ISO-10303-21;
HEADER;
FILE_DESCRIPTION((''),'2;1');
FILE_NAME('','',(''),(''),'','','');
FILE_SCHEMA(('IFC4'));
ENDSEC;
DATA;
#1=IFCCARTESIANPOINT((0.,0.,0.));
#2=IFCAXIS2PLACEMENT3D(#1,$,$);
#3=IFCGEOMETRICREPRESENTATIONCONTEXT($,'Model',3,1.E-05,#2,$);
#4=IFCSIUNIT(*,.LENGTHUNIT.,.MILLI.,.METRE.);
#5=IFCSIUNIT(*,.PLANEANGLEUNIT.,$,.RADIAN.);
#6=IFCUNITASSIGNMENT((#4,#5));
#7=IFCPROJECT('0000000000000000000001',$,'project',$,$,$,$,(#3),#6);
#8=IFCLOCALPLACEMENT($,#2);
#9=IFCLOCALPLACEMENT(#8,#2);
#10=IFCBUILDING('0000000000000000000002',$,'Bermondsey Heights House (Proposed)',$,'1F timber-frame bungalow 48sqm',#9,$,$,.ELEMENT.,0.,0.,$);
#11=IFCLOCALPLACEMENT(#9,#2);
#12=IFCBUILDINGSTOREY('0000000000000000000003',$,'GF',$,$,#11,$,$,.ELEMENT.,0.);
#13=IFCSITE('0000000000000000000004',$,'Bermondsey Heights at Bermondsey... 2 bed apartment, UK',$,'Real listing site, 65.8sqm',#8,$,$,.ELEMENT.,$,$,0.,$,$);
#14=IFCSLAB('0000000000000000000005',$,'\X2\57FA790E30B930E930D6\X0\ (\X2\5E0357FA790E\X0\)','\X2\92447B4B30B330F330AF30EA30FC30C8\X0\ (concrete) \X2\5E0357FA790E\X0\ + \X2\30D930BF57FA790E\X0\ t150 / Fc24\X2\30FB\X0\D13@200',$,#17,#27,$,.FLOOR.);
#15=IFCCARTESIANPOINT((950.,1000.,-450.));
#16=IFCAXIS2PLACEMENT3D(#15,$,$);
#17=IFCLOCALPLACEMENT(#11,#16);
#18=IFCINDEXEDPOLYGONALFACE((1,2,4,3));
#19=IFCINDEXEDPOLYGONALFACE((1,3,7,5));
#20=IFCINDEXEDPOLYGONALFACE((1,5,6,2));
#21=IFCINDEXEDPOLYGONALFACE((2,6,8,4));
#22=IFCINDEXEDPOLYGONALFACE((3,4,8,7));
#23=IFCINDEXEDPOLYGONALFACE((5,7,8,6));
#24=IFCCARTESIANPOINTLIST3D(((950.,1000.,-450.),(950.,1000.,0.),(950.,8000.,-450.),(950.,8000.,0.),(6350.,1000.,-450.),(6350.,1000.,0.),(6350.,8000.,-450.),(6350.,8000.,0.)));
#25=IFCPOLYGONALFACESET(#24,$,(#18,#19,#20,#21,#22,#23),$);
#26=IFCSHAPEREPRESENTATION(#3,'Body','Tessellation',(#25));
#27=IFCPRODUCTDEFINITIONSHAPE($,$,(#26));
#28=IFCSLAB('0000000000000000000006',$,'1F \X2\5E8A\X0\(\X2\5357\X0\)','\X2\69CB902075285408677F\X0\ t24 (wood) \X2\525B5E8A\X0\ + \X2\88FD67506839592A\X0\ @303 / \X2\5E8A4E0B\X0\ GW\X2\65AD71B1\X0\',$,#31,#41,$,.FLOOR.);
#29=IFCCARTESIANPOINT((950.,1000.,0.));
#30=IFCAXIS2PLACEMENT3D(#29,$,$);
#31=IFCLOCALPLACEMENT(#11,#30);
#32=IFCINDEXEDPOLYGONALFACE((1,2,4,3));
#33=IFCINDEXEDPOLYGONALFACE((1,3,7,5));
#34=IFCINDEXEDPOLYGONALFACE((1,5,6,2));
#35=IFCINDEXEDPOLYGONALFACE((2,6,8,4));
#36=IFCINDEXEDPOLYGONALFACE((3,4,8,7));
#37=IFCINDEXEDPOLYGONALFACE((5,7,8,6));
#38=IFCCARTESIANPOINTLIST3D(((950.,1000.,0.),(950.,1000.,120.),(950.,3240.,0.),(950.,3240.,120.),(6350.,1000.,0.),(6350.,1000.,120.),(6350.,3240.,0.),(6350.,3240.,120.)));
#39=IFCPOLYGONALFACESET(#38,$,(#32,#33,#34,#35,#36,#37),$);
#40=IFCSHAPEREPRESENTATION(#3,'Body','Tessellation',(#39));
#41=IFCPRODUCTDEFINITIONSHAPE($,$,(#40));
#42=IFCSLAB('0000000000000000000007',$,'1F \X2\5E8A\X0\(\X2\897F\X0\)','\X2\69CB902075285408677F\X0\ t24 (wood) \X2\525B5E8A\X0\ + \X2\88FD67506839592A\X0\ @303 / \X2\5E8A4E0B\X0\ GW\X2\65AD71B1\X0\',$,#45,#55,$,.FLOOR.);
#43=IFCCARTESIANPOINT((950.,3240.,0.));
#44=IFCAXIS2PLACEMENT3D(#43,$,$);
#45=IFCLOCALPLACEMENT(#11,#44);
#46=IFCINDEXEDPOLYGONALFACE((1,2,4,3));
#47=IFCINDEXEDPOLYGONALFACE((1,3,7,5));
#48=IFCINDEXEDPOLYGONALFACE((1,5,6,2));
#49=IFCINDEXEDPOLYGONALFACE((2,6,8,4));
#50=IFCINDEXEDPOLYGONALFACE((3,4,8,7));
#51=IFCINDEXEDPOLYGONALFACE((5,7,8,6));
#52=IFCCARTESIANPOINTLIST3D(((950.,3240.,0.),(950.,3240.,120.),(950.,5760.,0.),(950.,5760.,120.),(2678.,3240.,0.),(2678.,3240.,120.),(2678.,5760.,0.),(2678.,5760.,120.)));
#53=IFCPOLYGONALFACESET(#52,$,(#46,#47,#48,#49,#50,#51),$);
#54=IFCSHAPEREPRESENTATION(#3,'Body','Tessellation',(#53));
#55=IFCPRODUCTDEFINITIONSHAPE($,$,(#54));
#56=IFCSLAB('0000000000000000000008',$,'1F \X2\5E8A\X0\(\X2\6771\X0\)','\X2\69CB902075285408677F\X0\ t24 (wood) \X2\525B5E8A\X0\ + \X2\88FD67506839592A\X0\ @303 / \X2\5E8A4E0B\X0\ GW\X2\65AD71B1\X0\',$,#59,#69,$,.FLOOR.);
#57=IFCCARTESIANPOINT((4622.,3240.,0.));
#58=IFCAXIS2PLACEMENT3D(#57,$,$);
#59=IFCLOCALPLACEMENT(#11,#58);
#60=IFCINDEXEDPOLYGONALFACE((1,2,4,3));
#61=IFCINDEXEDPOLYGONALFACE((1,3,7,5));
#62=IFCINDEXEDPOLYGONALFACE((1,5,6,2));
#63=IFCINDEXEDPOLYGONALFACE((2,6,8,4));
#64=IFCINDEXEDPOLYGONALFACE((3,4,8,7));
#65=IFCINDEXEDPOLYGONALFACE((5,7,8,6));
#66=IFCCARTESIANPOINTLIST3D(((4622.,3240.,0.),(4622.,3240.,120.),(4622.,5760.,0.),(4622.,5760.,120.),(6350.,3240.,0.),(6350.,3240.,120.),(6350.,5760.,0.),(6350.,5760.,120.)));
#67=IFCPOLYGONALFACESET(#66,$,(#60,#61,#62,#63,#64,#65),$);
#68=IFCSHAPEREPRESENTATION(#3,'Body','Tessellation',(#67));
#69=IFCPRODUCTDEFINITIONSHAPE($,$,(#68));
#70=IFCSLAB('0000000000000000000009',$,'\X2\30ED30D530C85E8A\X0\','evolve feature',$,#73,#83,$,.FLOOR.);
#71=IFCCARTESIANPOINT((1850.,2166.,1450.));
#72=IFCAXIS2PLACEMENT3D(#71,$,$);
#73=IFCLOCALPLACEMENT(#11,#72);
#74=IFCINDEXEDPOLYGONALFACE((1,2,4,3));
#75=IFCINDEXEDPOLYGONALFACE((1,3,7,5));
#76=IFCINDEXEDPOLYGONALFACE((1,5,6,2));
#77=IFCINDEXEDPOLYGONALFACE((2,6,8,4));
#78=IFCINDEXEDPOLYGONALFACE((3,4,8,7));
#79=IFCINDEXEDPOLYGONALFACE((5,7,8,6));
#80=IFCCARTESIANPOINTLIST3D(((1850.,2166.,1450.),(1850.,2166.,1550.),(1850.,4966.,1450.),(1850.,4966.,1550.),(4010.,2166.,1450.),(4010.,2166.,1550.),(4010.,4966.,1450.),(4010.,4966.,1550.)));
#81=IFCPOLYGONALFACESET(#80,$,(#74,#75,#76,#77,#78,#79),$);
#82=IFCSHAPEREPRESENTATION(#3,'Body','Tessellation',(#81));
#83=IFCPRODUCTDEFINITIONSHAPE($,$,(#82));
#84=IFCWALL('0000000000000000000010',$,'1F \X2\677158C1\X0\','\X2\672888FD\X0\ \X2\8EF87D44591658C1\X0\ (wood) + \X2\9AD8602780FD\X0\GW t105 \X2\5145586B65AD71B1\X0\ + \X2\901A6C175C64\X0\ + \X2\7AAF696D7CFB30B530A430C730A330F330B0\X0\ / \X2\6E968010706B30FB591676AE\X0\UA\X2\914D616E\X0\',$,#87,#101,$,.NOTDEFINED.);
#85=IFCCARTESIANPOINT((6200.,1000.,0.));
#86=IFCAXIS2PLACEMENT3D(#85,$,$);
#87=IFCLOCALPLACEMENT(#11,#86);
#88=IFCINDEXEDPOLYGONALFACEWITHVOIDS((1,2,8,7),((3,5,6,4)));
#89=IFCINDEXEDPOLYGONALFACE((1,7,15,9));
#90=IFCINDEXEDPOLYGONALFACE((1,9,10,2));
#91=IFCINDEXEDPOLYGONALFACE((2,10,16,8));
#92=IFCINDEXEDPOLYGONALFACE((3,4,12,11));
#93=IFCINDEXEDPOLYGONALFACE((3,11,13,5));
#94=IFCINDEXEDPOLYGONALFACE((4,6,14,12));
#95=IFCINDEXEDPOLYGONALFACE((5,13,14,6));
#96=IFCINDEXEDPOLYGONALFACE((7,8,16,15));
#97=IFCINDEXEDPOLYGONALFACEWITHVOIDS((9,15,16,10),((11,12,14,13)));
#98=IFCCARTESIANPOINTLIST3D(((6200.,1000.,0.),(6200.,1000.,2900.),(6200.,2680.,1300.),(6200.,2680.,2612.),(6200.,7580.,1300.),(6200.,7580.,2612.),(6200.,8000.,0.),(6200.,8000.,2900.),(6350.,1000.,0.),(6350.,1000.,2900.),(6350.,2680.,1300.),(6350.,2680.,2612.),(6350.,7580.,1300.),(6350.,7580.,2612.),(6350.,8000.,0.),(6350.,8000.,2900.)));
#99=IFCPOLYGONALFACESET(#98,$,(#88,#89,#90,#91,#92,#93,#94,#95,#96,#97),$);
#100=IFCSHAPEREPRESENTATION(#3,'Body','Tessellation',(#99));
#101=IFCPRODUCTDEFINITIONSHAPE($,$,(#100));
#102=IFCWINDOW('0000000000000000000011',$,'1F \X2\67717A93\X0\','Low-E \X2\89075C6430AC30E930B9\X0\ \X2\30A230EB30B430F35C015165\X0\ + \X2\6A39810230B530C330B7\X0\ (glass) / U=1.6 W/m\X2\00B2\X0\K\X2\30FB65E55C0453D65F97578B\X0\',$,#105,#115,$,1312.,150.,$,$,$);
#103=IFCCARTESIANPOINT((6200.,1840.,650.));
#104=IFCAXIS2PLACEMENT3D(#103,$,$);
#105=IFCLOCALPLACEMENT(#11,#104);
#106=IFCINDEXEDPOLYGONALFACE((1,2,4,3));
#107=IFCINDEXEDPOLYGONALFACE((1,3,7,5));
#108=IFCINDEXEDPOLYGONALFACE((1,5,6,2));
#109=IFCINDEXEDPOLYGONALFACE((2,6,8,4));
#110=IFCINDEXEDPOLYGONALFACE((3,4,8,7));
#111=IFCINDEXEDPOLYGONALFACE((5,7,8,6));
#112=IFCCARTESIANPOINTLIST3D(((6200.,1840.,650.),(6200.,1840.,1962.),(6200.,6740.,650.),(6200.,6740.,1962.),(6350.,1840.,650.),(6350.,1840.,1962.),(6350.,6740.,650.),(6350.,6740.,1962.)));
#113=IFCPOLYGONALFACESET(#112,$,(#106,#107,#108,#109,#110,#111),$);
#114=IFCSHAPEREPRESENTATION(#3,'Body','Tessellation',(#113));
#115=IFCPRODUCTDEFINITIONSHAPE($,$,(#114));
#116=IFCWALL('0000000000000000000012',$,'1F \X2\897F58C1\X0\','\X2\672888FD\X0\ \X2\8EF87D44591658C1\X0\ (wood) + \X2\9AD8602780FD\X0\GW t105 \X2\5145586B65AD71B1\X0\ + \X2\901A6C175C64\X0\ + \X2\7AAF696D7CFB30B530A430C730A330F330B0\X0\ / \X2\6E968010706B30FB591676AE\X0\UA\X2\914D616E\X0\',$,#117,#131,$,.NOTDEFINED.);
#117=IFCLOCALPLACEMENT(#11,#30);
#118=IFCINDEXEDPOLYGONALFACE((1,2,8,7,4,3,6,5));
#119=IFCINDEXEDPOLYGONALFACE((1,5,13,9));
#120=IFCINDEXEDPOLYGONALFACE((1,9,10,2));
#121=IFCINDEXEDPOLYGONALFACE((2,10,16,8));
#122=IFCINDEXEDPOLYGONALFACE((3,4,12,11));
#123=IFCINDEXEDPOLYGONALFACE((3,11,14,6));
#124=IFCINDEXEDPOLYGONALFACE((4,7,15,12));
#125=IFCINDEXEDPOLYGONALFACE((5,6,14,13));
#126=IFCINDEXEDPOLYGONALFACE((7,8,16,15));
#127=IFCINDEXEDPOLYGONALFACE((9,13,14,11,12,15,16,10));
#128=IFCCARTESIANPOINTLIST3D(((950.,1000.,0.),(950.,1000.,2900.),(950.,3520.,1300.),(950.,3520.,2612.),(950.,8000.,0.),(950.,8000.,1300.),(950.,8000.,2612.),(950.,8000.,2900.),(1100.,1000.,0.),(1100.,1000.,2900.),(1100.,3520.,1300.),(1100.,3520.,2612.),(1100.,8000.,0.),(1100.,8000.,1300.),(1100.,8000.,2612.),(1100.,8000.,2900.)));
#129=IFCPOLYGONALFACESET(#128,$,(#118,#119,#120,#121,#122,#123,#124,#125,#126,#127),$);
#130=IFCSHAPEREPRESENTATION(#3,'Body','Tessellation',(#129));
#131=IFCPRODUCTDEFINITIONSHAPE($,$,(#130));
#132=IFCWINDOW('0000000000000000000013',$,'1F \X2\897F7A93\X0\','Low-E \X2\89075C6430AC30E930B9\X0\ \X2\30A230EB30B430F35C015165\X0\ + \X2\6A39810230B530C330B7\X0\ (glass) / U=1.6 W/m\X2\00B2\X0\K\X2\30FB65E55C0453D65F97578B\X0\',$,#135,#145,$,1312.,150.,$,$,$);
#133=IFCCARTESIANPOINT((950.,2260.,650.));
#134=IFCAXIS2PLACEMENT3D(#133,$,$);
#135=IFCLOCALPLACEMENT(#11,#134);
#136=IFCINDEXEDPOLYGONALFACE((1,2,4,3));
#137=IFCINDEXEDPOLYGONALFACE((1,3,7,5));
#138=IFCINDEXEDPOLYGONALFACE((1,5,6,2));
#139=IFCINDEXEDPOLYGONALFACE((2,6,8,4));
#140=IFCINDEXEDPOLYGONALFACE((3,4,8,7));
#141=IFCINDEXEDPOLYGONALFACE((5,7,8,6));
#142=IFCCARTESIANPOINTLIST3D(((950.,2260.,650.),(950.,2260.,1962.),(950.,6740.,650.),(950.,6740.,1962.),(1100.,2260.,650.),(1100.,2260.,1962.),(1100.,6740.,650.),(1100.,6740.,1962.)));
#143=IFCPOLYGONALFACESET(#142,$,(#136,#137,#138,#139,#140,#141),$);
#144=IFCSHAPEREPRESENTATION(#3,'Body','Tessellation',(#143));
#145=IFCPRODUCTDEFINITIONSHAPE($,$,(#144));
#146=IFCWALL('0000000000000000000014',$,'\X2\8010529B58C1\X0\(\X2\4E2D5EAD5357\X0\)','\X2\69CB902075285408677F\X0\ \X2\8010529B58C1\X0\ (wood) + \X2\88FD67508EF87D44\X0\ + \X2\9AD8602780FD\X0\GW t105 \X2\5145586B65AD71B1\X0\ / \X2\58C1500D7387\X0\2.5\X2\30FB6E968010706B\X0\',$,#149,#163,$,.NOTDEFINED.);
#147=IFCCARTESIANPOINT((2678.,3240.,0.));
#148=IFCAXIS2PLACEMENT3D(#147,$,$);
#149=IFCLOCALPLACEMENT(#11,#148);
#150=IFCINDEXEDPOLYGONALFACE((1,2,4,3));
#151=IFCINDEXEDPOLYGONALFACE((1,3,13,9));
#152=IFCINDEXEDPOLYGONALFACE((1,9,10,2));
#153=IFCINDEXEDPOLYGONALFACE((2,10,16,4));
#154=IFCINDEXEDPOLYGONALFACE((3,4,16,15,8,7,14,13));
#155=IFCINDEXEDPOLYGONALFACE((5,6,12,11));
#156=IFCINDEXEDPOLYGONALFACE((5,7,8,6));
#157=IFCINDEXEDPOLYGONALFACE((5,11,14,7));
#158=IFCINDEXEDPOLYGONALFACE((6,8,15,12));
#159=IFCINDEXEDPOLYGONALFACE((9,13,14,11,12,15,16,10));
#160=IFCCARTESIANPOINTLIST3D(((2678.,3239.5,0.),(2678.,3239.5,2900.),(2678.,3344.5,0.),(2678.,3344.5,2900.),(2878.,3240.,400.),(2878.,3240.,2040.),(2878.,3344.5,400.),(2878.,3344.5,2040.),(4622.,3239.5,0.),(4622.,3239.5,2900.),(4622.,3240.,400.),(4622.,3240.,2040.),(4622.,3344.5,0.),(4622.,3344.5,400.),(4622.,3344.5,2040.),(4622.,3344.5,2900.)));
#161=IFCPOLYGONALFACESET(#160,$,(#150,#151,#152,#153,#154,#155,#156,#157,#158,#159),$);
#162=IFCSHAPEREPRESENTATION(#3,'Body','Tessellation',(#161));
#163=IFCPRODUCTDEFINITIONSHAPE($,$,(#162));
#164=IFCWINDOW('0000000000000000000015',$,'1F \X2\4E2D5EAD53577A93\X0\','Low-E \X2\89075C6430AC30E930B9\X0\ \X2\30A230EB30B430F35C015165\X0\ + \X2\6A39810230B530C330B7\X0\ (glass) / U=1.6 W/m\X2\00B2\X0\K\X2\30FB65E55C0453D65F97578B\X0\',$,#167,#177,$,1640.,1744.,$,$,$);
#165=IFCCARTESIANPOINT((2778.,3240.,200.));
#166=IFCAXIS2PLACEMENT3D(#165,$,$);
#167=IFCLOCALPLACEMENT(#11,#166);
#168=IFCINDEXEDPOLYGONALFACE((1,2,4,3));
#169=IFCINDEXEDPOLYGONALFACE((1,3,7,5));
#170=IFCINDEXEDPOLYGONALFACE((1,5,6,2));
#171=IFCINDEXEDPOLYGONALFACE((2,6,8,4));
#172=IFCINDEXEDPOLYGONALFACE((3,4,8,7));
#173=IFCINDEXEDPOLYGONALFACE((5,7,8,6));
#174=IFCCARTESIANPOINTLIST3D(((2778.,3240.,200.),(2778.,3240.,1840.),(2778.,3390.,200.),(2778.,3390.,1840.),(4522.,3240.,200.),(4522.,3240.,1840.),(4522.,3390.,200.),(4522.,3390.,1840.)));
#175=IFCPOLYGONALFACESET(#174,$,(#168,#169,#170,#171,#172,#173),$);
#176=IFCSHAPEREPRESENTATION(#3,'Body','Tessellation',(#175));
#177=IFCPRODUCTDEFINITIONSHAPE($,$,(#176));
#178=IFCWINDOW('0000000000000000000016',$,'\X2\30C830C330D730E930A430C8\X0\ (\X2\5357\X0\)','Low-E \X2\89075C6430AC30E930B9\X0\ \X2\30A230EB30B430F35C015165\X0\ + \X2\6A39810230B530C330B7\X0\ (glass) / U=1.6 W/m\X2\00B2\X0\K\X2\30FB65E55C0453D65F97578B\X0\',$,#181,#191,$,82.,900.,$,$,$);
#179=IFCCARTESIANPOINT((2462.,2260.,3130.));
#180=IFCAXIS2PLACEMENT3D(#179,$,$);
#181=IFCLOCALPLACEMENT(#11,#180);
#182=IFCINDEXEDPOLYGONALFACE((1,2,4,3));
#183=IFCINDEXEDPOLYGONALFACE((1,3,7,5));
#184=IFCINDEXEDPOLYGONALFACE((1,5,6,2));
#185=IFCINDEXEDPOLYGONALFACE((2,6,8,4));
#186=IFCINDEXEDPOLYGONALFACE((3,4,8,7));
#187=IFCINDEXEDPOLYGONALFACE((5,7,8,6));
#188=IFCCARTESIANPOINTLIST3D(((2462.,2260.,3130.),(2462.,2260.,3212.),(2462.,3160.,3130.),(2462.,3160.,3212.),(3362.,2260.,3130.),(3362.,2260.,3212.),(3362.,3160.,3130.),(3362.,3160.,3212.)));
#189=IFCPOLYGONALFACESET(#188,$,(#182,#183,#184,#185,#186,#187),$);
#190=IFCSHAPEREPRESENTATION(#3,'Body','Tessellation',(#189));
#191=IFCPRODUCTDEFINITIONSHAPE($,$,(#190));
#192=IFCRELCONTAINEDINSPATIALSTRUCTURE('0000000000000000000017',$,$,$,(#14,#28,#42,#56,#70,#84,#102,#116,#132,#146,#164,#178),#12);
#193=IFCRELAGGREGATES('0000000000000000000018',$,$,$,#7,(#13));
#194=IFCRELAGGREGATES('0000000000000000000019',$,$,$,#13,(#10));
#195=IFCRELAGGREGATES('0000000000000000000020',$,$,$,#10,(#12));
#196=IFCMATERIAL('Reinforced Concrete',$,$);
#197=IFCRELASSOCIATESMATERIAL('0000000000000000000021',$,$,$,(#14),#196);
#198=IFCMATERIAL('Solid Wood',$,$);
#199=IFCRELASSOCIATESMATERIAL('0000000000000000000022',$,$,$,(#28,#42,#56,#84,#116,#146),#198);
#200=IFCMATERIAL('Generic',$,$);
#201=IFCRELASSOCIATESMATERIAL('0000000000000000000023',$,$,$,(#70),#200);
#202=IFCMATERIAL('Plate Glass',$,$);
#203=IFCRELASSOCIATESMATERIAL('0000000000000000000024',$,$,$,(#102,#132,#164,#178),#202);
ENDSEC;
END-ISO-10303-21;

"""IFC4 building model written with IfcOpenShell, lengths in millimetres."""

from ifc_helpers import new_model, si_unit, frame, frame_2d, origin, place, context, project, spatial, rectangle, extrude, material, element, fill, save


model = new_model("IFC4")

# Units and contexts
model_context = context("Model", 3, precision=1e-05, world=origin())
ifc_project = project(units=[si_unit("LENGTHUNIT", "METRE", prefix="MILLI"), si_unit("PLANEANGLEUNIT", "RADIAN")], contexts=[model_context])

# Site, building, storey
site_placement = place(None, origin())
site = spatial("IfcSite", under=ifc_project, at=site_placement, Name="Bermondsey Heights at Bermondsey... 2 bed apartment, UK", ObjectType="Real listing site, 65.8sqm", CompositionType="ELEMENT", RefElevation=0.0)
building_placement = place(site_placement, origin())
building = spatial("IfcBuilding", under=site, at=building_placement, Name="Bermondsey Heights House (Proposed)", ObjectType="1F timber-frame bungalow 48sqm", CompositionType="ELEMENT", ElevationOfRefHeight=0.0, ElevationOfTerrain=0.0)
storey_placement = place(building_placement, origin())
storey = spatial("IfcBuildingStorey", under=building, at=storey_placement, Name="GF", CompositionType="ELEMENT", Elevation=0.0)

# Slabs
ifc_material_1 = material(Name="Reinforced Concrete")
slab_1_placement = place(storey_placement, frame((950.0, 1000.0, -450.0)))
element("IfcSlab", 1, at=slab_1_placement, inside=storey, material=ifc_material_1, Name="基礎スラブ (布基礎)", Description="鉄筋コンクリート (concrete) 布基礎 + ベタ基礎 t150 / Fc24・D13@200", PredefinedType="FLOOR", context=model_context, shape_type="SweptSolid", body=[
    extrude(rectangle(XDim=5400.0, YDim=7000.0, at=frame_2d((2700.0, 3500.0))), frame((950.0, 1000.0, -450.0)), (0.0, 0.0, 1.0), 450.0),
])
ifc_material_2 = material(Name="Solid Wood")
slab_2_placement = place(storey_placement, frame((950.0, 1000.0, 0.0)))
element("IfcSlab", 2, at=slab_2_placement, inside=storey, material=ifc_material_2, Name="1F 床(南)", Description="構造用合板 t24 (wood) 剛床 + 製材根太 @303 / 床下 GW断熱", PredefinedType="FLOOR", context=model_context, shape_type="SweptSolid", body=[
    extrude(rectangle(XDim=5400.0, YDim=2240.0, at=frame_2d((2700.0, 1120.0))), frame((950.0, 1000.0, 0.0)), (0.0, 0.0, 1.0), 120.0),
])
slab_3_placement = place(storey_placement, frame((950.0, 3240.0, 0.0)))
element("IfcSlab", 3, at=slab_3_placement, inside=storey, material=ifc_material_2, Name="1F 床(西)", Description="構造用合板 t24 (wood) 剛床 + 製材根太 @303 / 床下 GW断熱", PredefinedType="FLOOR", context=model_context, shape_type="SweptSolid", body=[
    extrude(rectangle(XDim=1728.0, YDim=2520.0, at=frame_2d((864.0, 1260.0))), frame((950.0, 3240.0, 0.0)), (0.0, 0.0, 1.0), 120.0),
])
slab_4_placement = place(storey_placement, frame((4622.0, 3240.0, 0.0)))
element("IfcSlab", 4, at=slab_4_placement, inside=storey, material=ifc_material_2, Name="1F 床(東)", Description="構造用合板 t24 (wood) 剛床 + 製材根太 @303 / 床下 GW断熱", PredefinedType="FLOOR", context=model_context, shape_type="SweptSolid", body=[
    extrude(rectangle(XDim=1728.0, YDim=2520.0, at=frame_2d((864.0, 1260.0))), frame((4622.0, 3240.0, 0.0)), (0.0, 0.0, 1.0), 120.0),
])
ifc_material_3 = material(Name="Generic")
slab_5_placement = place(storey_placement, frame((1850.0, 2166.0, 1450.0)))
element("IfcSlab", 5, at=slab_5_placement, inside=storey, material=ifc_material_3, Name="ロフト床", Description="evolve feature", PredefinedType="FLOOR", context=model_context, shape_type="SweptSolid", body=[
    extrude(rectangle(XDim=2160.0, YDim=2800.0, at=frame_2d((1080.0, 1400.0))), frame((1850.0, 2166.0, 1450.0)), (0.0, 0.0, 1.0), 100.0),
])

# Shared definitions
ifc_material_4 = material(Name="Plate Glass")

# Walls, openings, windows
wall_1_placement = place(storey_placement, frame((6200.0, 1000.0, 0.0)))
wall_1 = element("IfcWall", 6, at=wall_1_placement, inside=storey, material=ifc_material_2, Name="1F 東壁", Description="木製 軸組外壁 (wood) + 高性能GW t105 充填断熱 + 通気層 + 窯業系サイディング / 準耐火・外皮UA配慮", PredefinedType="NOTDEFINED", context=model_context, shape_type="SweptSolid", body=[
    extrude(rectangle(XDim=150.0, YDim=7000.0, at=frame_2d((75.0, 3500.0))), frame((6200.0, 1000.0, 0.0)), (0.0, 0.0, 1.0), 2900.0),
])
opening_1_placement = place(storey_placement, frame((6200.0, 1840.0, 650.0)))
opening_1 = element("IfcOpeningElement", 7, at=opening_1_placement, cuts=wall_1, PredefinedType="NOTDEFINED", context=model_context, shape_type="SweptSolid", body=[
    extrude(rectangle(XDim=150.0, YDim=4900.0, at=frame_2d((75.0, 2450.0))), frame((6200.0, 1840.0, 650.0)), (0.0, 0.0, 1.0), 1312.0),
])
window_1_placement = place(storey_placement, frame((6200.0, 1840.0, 650.0)))
window_1 = element("IfcWindow", 8, at=window_1_placement, inside=storey, material=ifc_material_4, Name="1F 東窓", Description="Low-E 複層ガラス アルゴン封入 + 樹脂サッシ (glass) / U=1.6 W/m²K・日射取得型", OverallHeight=1312.0, OverallWidth=150.0, context=model_context, shape_type="SweptSolid", body=[
    extrude(rectangle(XDim=150.0, YDim=4900.0, at=frame_2d((75.0, 2450.0))), frame((6200.0, 1840.0, 650.0)), (0.0, 0.0, 1.0), 1312.0),
])
fill(opening_1, window_1)
wall_2_placement = place(storey_placement, frame((950.0, 1000.0, 0.0)))
wall_2 = element("IfcWall", 9, at=wall_2_placement, inside=storey, material=ifc_material_2, Name="1F 西壁", Description="木製 軸組外壁 (wood) + 高性能GW t105 充填断熱 + 通気層 + 窯業系サイディング / 準耐火・外皮UA配慮", PredefinedType="NOTDEFINED", context=model_context, shape_type="SweptSolid", body=[
    extrude(rectangle(XDim=150.0, YDim=7000.0, at=frame_2d((75.0, 3500.0))), frame((950.0, 1000.0, 0.0)), (0.0, 0.0, 1.0), 2900.0),
])
opening_2_placement = place(storey_placement, frame((950.0, 2260.0, 650.0)))
opening_2 = element("IfcOpeningElement", 10, at=opening_2_placement, cuts=wall_2, PredefinedType="NOTDEFINED", context=model_context, shape_type="SweptSolid", body=[
    extrude(rectangle(XDim=150.0, YDim=4480.0, at=frame_2d((75.0, 2240.0))), frame((950.0, 2260.0, 650.0)), (0.0, 0.0, 1.0), 1312.0),
])
window_2_placement = place(storey_placement, frame((950.0, 2260.0, 650.0)))
window_2 = element("IfcWindow", 11, at=window_2_placement, inside=storey, material=ifc_material_4, Name="1F 西窓", Description="Low-E 複層ガラス アルゴン封入 + 樹脂サッシ (glass) / U=1.6 W/m²K・日射取得型", OverallHeight=1312.0, OverallWidth=150.0, context=model_context, shape_type="SweptSolid", body=[
    extrude(rectangle(XDim=150.0, YDim=4480.0, at=frame_2d((75.0, 2240.0))), frame((950.0, 2260.0, 650.0)), (0.0, 0.0, 1.0), 1312.0),
])
fill(opening_2, window_2)
wall_3_placement = place(storey_placement, frame((2678.0, 3240.0, 0.0)))
wall_3 = element("IfcWall", 12, at=wall_3_placement, inside=storey, material=ifc_material_2, Name="耐力壁(中庭南)", Description="構造用合板 耐力壁 (wood) + 製材軸組 + 高性能GW t105 充填断熱 / 壁倍率2.5・準耐火", PredefinedType="NOTDEFINED", context=model_context, shape_type="SweptSolid", body=[
    extrude(rectangle(XDim=1944.0, YDim=105.0, at=frame_2d((972.0, 52.0))), frame((2678.0, 3240.0, 0.0)), (0.0, 0.0, 1.0), 2900.0),
])
opening_3_placement = place(storey_placement, frame((2778.0, 3240.0, 200.0)))
opening_3 = element("IfcOpeningElement", 13, at=opening_3_placement, cuts=wall_3, PredefinedType="NOTDEFINED", context=model_context, shape_type="SweptSolid", body=[
    extrude(rectangle(XDim=1744.0, YDim=150.0, at=frame_2d((872.0, 75.0))), frame((2778.0, 3240.0, 200.0)), (0.0, 0.0, 1.0), 1640.0),
])
window_3_placement = place(storey_placement, frame((2778.0, 3240.0, 200.0)))
window_3 = element("IfcWindow", 14, at=window_3_placement, inside=storey, material=ifc_material_4, Name="1F 中庭南窓", Description="Low-E 複層ガラス アルゴン封入 + 樹脂サッシ (glass) / U=1.6 W/m²K・日射取得型", OverallHeight=1640.0, OverallWidth=1744.0, context=model_context, shape_type="SweptSolid", body=[
    extrude(rectangle(XDim=1744.0, YDim=150.0, at=frame_2d((872.0, 75.0))), frame((2778.0, 3240.0, 200.0)), (0.0, 0.0, 1.0), 1640.0),
])
fill(opening_3, window_3)

# Window
window_4_placement = place(storey_placement, frame((2462.0, 2260.0, 3130.0)))
element("IfcWindow", 15, at=window_4_placement, inside=storey, material=ifc_material_4, Name="トップライト (南)", Description="Low-E 複層ガラス アルゴン封入 + 樹脂サッシ (glass) / U=1.6 W/m²K・日射取得型", OverallHeight=82.0, OverallWidth=900.0, context=model_context, shape_type="SweptSolid", body=[
    extrude(rectangle(XDim=900.0, YDim=900.0, at=frame_2d((450.0, 450.0))), frame((2462.0, 2260.0, 3130.0)), (0.0, 0.0, 1.0), 82.0),
])

save(model, "model.ifc")
